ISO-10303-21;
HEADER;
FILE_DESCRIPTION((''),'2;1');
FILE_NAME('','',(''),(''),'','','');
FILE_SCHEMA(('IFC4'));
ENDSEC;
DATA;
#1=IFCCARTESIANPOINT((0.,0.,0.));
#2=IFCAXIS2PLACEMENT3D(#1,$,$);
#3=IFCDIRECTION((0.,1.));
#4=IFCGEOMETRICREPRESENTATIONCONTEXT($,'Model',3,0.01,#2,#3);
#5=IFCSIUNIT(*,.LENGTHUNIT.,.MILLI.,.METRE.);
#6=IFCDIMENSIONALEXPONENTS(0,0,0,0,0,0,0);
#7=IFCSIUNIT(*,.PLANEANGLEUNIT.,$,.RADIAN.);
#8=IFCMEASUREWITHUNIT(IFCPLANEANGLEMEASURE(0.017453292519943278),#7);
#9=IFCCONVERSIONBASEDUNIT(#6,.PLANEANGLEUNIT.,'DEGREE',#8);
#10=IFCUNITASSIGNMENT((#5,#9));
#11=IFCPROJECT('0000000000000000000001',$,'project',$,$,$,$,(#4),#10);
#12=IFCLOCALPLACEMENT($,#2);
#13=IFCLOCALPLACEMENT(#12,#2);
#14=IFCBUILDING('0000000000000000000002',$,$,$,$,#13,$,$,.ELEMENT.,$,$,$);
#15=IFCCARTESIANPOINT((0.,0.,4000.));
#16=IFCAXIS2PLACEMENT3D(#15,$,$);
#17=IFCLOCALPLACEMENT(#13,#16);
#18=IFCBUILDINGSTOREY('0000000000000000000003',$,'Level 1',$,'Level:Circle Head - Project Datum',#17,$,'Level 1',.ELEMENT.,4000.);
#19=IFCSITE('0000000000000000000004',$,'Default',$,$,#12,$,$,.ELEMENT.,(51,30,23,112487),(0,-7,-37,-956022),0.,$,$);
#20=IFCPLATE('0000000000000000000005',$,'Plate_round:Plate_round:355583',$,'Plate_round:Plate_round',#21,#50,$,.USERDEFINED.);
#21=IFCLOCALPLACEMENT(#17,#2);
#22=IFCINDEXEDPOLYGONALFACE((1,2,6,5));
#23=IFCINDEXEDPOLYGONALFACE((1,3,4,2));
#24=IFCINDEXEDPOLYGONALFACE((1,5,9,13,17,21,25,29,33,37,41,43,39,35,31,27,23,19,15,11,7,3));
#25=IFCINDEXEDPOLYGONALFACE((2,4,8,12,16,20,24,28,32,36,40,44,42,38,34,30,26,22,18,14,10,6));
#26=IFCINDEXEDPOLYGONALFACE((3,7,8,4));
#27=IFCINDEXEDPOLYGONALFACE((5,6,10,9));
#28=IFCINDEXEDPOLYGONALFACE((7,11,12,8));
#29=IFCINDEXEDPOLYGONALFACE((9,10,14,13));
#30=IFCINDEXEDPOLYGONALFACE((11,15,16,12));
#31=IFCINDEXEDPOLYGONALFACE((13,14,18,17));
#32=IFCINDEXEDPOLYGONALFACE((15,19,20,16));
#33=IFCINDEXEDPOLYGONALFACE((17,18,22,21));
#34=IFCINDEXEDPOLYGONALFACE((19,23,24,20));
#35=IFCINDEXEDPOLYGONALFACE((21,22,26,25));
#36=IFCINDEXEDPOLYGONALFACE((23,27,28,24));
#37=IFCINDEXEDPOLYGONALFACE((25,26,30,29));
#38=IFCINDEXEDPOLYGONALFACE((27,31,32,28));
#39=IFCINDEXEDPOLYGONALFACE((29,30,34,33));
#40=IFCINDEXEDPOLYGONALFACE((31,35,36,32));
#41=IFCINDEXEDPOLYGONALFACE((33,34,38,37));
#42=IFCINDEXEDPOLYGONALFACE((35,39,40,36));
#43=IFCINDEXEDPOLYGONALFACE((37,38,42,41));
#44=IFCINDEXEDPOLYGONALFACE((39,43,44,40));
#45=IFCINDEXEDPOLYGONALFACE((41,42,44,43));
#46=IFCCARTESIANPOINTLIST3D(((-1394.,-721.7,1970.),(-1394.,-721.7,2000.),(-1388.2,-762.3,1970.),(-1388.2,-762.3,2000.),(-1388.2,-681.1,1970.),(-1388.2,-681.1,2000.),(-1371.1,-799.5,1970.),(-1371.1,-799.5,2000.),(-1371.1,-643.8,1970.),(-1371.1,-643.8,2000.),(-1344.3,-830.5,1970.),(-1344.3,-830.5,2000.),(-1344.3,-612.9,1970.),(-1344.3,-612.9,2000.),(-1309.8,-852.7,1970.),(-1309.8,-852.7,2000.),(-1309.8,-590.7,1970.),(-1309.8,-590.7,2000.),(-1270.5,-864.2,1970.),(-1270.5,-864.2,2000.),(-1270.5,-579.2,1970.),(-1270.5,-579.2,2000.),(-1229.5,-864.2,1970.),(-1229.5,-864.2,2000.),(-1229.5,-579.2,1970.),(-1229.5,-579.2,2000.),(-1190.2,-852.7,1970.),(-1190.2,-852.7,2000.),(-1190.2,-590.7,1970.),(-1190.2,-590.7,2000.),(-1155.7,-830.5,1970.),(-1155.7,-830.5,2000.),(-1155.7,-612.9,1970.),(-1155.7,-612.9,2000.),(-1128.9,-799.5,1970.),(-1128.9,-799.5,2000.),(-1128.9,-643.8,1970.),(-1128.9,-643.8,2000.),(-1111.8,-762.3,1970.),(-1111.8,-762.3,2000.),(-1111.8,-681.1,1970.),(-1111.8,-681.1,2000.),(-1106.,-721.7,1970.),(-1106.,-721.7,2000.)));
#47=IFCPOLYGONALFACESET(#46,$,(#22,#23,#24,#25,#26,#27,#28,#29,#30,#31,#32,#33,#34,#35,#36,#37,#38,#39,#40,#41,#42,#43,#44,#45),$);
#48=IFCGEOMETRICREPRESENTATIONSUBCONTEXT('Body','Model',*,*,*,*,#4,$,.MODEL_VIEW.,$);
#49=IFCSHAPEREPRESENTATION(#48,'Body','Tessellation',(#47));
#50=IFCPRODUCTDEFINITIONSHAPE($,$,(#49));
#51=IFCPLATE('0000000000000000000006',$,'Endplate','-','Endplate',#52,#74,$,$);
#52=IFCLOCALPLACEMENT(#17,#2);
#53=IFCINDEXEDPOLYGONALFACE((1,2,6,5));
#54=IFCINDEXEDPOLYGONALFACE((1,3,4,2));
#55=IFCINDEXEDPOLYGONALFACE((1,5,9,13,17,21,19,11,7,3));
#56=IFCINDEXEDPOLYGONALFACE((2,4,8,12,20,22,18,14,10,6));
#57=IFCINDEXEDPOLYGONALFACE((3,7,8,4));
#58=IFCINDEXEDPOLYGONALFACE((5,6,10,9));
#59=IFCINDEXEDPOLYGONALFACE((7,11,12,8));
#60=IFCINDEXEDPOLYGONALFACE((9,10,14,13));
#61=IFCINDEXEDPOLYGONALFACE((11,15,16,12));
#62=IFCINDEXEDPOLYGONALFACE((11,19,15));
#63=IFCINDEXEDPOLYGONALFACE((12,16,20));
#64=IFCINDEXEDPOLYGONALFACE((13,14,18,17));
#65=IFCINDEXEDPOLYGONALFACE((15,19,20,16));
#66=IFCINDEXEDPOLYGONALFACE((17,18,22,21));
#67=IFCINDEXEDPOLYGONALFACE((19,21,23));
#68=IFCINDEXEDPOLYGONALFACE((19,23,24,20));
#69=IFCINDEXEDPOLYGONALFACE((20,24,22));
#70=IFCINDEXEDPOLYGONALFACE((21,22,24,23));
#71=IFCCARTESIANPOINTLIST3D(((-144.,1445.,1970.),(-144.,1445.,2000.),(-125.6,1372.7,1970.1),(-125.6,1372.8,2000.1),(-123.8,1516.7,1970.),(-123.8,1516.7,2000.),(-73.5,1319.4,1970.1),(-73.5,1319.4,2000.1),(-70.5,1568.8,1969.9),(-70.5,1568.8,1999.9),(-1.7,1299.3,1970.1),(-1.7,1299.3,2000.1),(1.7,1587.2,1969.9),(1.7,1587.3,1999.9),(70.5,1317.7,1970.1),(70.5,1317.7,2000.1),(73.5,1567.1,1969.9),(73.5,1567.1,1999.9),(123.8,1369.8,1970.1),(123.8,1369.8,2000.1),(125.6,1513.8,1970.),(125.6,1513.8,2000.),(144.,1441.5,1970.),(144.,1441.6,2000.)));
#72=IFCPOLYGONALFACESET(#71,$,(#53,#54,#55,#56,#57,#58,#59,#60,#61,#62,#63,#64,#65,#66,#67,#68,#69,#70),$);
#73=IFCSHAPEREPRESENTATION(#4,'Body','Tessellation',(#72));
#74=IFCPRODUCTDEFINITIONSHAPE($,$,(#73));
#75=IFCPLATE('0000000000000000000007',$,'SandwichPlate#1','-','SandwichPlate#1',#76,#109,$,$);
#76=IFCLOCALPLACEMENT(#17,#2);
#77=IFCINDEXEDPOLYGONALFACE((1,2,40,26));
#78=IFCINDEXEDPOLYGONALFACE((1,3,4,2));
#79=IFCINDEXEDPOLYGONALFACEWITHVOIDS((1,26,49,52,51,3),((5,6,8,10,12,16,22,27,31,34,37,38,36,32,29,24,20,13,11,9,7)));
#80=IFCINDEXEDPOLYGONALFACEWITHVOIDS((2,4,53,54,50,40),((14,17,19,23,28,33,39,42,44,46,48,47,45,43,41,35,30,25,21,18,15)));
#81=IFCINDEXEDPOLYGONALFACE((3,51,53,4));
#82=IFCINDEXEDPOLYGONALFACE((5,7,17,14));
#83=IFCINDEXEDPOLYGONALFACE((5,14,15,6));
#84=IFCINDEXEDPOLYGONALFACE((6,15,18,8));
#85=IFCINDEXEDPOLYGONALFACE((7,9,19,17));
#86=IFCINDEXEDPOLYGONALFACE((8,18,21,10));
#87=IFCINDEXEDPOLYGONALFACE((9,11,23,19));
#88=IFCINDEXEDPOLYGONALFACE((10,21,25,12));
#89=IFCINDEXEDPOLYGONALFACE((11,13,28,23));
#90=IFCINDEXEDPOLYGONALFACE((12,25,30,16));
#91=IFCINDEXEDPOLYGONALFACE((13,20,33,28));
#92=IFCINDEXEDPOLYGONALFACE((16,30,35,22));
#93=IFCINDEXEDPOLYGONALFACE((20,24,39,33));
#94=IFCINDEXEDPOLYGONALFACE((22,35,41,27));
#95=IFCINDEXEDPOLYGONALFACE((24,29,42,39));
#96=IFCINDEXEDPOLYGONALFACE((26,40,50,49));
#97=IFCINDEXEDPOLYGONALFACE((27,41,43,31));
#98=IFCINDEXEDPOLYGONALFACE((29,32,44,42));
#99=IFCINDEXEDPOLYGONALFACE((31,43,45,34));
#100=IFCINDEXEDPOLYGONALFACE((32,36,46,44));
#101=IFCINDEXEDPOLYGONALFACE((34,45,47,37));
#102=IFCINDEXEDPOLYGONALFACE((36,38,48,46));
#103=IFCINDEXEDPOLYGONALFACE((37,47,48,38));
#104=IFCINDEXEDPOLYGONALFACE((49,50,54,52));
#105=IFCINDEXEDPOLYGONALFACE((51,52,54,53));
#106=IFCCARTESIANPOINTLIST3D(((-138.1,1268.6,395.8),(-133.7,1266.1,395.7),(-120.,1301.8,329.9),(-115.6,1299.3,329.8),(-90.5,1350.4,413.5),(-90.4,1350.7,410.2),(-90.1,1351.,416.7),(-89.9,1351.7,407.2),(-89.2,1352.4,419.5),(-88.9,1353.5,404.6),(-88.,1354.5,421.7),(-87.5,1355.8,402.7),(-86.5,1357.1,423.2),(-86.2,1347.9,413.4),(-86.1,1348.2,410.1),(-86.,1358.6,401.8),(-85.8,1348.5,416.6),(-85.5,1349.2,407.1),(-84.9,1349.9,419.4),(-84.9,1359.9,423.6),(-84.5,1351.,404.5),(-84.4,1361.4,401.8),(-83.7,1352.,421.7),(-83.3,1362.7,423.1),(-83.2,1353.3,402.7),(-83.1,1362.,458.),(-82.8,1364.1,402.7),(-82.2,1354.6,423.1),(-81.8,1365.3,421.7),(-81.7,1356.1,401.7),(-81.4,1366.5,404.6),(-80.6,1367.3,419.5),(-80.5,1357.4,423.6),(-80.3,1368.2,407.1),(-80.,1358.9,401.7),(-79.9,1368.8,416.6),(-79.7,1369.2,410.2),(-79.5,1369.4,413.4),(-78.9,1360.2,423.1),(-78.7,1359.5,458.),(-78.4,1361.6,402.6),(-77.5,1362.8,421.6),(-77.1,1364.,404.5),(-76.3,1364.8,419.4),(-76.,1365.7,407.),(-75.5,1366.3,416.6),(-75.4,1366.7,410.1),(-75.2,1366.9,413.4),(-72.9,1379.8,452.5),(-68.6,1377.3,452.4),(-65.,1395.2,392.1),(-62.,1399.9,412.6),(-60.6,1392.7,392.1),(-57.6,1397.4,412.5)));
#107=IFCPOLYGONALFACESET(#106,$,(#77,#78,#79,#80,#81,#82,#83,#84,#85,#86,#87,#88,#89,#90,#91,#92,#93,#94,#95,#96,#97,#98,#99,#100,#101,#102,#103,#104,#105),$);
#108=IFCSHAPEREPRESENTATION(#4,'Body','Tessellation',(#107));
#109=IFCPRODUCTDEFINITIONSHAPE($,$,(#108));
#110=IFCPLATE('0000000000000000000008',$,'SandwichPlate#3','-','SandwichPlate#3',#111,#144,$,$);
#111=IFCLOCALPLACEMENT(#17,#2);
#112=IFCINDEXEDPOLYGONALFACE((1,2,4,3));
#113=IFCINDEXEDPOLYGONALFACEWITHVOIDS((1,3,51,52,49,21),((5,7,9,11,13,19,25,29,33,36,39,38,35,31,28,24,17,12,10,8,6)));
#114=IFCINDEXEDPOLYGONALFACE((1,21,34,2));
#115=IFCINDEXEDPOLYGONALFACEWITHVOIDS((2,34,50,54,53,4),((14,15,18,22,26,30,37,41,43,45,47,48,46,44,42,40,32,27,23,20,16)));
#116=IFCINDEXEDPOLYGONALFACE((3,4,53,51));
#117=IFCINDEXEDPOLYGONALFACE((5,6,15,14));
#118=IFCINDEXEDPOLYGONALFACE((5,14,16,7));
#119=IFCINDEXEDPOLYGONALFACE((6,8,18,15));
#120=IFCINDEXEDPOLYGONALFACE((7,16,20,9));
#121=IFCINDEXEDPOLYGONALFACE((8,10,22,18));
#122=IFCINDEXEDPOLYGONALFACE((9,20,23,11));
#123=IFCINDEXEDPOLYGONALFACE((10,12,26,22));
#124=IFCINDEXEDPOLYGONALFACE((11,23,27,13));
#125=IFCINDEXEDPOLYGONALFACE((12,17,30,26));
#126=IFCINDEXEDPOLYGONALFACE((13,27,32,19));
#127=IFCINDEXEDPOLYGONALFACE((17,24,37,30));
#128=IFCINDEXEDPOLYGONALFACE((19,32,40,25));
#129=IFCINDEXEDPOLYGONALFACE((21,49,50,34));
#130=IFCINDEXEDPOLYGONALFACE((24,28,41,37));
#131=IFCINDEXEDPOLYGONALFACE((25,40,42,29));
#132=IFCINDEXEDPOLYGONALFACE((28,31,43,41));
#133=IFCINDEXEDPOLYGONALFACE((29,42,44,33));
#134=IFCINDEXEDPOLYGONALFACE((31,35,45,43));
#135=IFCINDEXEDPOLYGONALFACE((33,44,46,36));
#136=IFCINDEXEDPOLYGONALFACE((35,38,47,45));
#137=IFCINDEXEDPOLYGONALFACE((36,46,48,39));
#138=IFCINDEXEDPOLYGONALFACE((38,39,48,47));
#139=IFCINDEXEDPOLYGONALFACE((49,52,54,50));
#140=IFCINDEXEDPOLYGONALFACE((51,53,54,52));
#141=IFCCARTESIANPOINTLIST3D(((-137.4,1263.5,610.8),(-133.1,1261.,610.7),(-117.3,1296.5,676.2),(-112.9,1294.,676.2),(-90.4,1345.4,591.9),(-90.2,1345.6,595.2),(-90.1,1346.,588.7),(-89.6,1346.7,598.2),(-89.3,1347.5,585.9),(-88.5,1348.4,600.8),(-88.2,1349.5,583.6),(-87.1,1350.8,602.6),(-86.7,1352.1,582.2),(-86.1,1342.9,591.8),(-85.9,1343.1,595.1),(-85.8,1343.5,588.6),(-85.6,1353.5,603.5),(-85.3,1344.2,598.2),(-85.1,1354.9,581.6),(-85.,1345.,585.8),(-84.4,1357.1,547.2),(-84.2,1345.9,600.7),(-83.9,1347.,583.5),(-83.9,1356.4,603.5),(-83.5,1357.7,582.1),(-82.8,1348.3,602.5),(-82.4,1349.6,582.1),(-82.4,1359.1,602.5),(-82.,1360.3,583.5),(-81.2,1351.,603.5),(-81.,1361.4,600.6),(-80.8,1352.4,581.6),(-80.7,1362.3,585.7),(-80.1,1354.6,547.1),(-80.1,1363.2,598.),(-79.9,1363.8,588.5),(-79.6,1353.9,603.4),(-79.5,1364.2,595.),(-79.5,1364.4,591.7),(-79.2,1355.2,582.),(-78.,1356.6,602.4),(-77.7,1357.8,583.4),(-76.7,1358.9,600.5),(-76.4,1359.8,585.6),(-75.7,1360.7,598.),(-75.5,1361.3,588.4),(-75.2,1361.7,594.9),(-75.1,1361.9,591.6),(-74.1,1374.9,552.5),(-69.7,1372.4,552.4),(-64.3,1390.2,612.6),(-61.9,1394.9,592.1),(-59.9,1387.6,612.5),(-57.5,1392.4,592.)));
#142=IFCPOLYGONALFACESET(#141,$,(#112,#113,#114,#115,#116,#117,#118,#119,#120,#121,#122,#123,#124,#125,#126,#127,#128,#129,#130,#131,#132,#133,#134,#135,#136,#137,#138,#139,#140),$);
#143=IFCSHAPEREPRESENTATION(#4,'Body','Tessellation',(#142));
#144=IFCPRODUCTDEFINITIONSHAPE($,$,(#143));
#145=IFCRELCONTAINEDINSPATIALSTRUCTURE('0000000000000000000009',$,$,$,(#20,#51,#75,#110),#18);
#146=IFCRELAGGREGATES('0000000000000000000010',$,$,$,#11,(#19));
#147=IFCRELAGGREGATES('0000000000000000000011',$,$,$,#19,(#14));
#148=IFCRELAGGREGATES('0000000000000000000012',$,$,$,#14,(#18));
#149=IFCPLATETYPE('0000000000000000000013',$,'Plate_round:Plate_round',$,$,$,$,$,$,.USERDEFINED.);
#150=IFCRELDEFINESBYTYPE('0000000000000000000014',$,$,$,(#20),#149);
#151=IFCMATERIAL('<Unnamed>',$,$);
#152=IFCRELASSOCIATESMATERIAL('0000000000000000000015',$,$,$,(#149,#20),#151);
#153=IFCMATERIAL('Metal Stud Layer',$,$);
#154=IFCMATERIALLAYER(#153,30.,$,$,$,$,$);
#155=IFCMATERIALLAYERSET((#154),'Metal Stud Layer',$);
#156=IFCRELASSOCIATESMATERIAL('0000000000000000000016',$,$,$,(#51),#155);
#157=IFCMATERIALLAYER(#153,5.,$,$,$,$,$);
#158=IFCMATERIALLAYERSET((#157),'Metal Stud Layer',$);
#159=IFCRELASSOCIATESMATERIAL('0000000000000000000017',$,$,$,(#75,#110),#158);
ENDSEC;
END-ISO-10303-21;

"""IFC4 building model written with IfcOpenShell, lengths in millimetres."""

from ifc_helpers import new_model, entity, si_unit, converted_unit, point, direction, frame, frame_2d, origin, origin_with_axes, origin_2d_with_axis, place, context, subcontext, project, spatial, polyline, arc, indexed_curve, circle_curve, line_curve, trimmed, segment, composite_curve, circle, outline, extrude, source, transform, mapped, material, layer, layer_set, type_object, type_shapes, element, save


model = new_model("IFC4")

# Units and contexts
model_context = context("Model", 3, precision=0.01, world=origin(), true_north=direction((0.0, 1.0)))
body_context = subcontext(model_context, "Body", "Model", "MODEL_VIEW")
ifc_project = project(units=[si_unit("LENGTHUNIT", "METRE", prefix="MILLI"), converted_unit("PLANEANGLEUNIT", "DEGREE", entity("IfcPlaneAngleMeasure", 0.017453292519943278), si_unit("PLANEANGLEUNIT", "RADIAN"), dimensions=[0, 0, 0, 0, 0, 0, 0])], contexts=[model_context])

# Site, building, storey
site_placement = place(None, origin())
site = spatial("IfcSite", under=ifc_project, at=site_placement, Name="Default", CompositionType="ELEMENT", RefLatitude=(51, 30, 23, 112487), RefLongitude=(0, -7, -37, -956022), RefElevation=0.0)
building_placement = place(site_placement, origin())
building = spatial("IfcBuilding", under=site, at=building_placement, CompositionType="ELEMENT")
storey_placement = place(building_placement, frame((0.0, 0.0, 4000.0)))
storey = spatial("IfcBuildingStorey", under=building, at=storey_placement, Name="Level 1", ObjectType="Level:Circle Head - Project Datum", LongName="Level 1", CompositionType="ELEMENT", Elevation=4000.0)

# Plate
ifc_material_1 = material(Name="<Unnamed>")
plate_type = type_object("IfcPlateType", Name="Plate_round:Plate_round", PredefinedType="USERDEFINED", material=ifc_material_1)
shared_shape = source(origin(), body_context, "Body", "SweptSolid", [
    extrude(outline(indexed_curve([(-144.0, 0.0), (0.0, -144.0), (144.0, 0.0), (0.0, 144.0)], segments=[arc(1, 2, 3), arc(3, 4, 1)], self_intersect=False)), origin(), (0.0, 0.0, 1.0), 30.0),
])
type_shapes(plate_type, [shared_shape])
plate_1_placement = place(storey_placement, frame((-1250.0, -721.7, 1970.0)))
element("IfcPlate", 1, at=plate_1_placement, inside=storey, type_object=plate_type, material=ifc_material_1, Name="Plate_round:Plate_round:355583", ObjectType="Plate_round:Plate_round", PredefinedType="USERDEFINED", context=body_context, shape_type="MappedRepresentation", body=[
    mapped(shared_shape, transform((0.0, 0.0, 0.0), scale=1.0)),
])

# Plates, openings
ifc_material_2 = material(Name="Metal Stud Layer")
ifc_layer_1 = layer(ifc_material_2, 30.0)
ifc_layer_set_1 = layer_set([ifc_layer_1], Name="Metal Stud Layer")
plate_2_placement = place(storey_placement, frame((-144.0, 1445.0, 1970.0), z_axis=(0.0, 0.000811, 1.0), x_axis=(-0.011883, -0.999929, 0.000811)))
plate_2 = element("IfcPlate", 2, at=plate_2_placement, inside=storey, material=ifc_layer_set_1, Name="Endplate", Description="-", ObjectType="Endplate", context=model_context, shape_type="SweptSolid", body=[
    extrude(outline(polyline([(144.0, 0.0), (144.0, 288.0), (-144.0, 288.0), (-144.0, 0.0), (144.0, 0.0)])), origin_with_axes(), (0.0, 0.0, 1.0), 30.0),
])
opening_1_placement = place(plate_2_placement, frame((0.0, 0.0, 0.0), z_axis=(0.0, 0.0, 1.0), x_axis=(1.0, 0.0, 0.0)))
element("IfcOpeningElement", 3, at=opening_1_placement, cuts=plate_2, ObjectType="Opening", context=model_context, shape_type="SweptSolid", body=[
    extrude(outline(composite_curve([segment(trimmed(line_curve((144.0, 0.0), (0.0, 1.0), 144.0), [point((144.0, 0.0))], [point((144.0, 144.0))], True, "CARTESIAN"), True, "CONTINUOUS"), segment(trimmed(circle_curve(frame_2d((0.0, 144.0), x_axis=(-1.0, 0.0)), 144.0), [point((144.0, 144.0))], [point((0.0, 0.0))], False, "CARTESIAN"), True, "CONTINUOUS"), segment(trimmed(line_curve((0.0, 0.0), (1.0, 0.0), 144.0), [point((0.0, 0.0))], [point((144.0, 0.0))], True, "CARTESIAN"), True, "CONTINUOUS")], self_intersect="UNKNOWN")), origin(), (0.0, 0.0, 1.0), 30.0),
])
opening_2_placement = place(plate_2_placement, frame((0.0, 0.0, 0.0), z_axis=(0.0, 0.0, 1.0), x_axis=(1.0, 0.0, 0.0)))
element("IfcOpeningElement", 4, at=opening_2_placement, cuts=plate_2, ObjectType="Opening", context=model_context, shape_type="SweptSolid", body=[
    extrude(outline(composite_curve([segment(trimmed(line_curve((144.0, 288.0), (-1.0, 0.0), 144.0), [point((144.0, 288.0))], [point((0.0, 288.0))], True, "CARTESIAN"), True, "CONTINUOUS"), segment(trimmed(circle_curve(frame_2d((0.0, 144.0), x_axis=(-1.0, 0.0)), 144.0), [point((0.0, 288.0))], [point((144.0, 144.0))], False, "CARTESIAN"), True, "CONTINUOUS"), segment(trimmed(line_curve((144.0, 144.0), (0.0, 1.0), 144.0), [point((144.0, 144.0))], [point((144.0, 288.0))], True, "CARTESIAN"), True, "CONTINUOUS")], self_intersect="UNKNOWN")), origin(), (0.0, 0.0, 1.0), 30.0),
])
opening_3_placement = place(plate_2_placement, frame((0.0, 0.0, 0.0), z_axis=(0.0, 0.0, 1.0), x_axis=(1.0, 0.0, 0.0)))
element("IfcOpeningElement", 5, at=opening_3_placement, cuts=plate_2, ObjectType="Opening", context=model_context, shape_type="SweptSolid", body=[
    extrude(outline(composite_curve([segment(trimmed(line_curve((-144.0, 288.0), (0.0, -1.0), 144.0), [point((-144.0, 288.0))], [point((-144.0, 144.0))], True, "CARTESIAN"), True, "CONTINUOUS"), segment(trimmed(circle_curve(frame_2d((0.0, 144.0), x_axis=(-1.0, 0.0)), 144.0), [point((-144.0, 144.0))], [point((0.0, 288.0))], False, "CARTESIAN"), True, "CONTINUOUS"), segment(trimmed(line_curve((0.0, 288.0), (-1.0, 0.0), 144.0), [point((0.0, 288.0))], [point((-144.0, 288.0))], True, "CARTESIAN"), True, "CONTINUOUS")], self_intersect="UNKNOWN")), origin(), (0.0, 0.0, 1.0), 30.0),
])
opening_4_placement = place(plate_2_placement, frame((0.0, 0.0, 0.0), z_axis=(0.0, 0.0, 1.0), x_axis=(1.0, 0.0, 0.0)))
element("IfcOpeningElement", 6, at=opening_4_placement, cuts=plate_2, ObjectType="Opening", context=model_context, shape_type="SweptSolid", body=[
    extrude(outline(composite_curve([segment(trimmed(line_curve((-144.0, 0.0), (1.0, 0.0), 144.0), [point((-144.0, 0.0))], [point((0.0, 0.0))], True, "CARTESIAN"), True, "CONTINUOUS"), segment(trimmed(circle_curve(frame_2d((0.0, 144.0), x_axis=(-1.0, 0.0)), 144.0), [point((0.0, 0.0))], [point((-144.0, 144.0))], False, "CARTESIAN"), True, "CONTINUOUS"), segment(trimmed(line_curve((-144.0, 144.0), (0.0, -1.0), 144.0), [point((-144.0, 144.0))], [point((-144.0, 0.0))], True, "CARTESIAN"), True, "CONTINUOUS")], self_intersect="UNKNOWN")), origin(), (0.0, 0.0, 1.0), 30.0),
])
ifc_layer_2 = layer(ifc_material_2, 5.0)
ifc_layer_set_2 = layer_set([ifc_layer_2], Name="Metal Stud Layer")
plate_3_placement = place(storey_placement, frame((-58.4, 1406.5, 399.6), z_axis=(0.865935, -0.499948, -0.014432), x_axis=(-0.238139, -0.437501, 0.867112)))
plate_3 = element("IfcPlate", 7, at=plate_3_placement, inside=storey, material=ifc_layer_set_2, Name="SandwichPlate#1", Description="-", ObjectType="SandwichPlate#1", context=model_context, shape_type="SweptSolid", body=[
    extrude(outline(polyline([(0.0, 0.0), (76.0, 0.0), (76.0, 140.0), (0.0, 140.0), (0.0, 0.0)])), origin_with_axes(), (0.0, 0.0, 1.0), 5.0),
])
opening_5_placement = place(plate_3_placement, frame((0.0, 0.0, 0.0), z_axis=(0.0, 0.0, 1.0), x_axis=(1.0, 0.0, 0.0)))
element("IfcOpeningElement", 8, at=opening_5_placement, cuts=plate_3, ObjectType="Opening", context=model_context, shape_type="SweptSolid", body=[
    extrude(outline(polyline([(0.0, 0.0), (15.0, 0.0), (0.0, 15.0), (0.0, 0.0)])), origin(), (0.0, 0.0, 1.0), 5.0),
])
opening_6_placement = place(plate_3_placement, frame((0.0, 0.0, 0.0), z_axis=(0.0, 0.0, 1.0), x_axis=(1.0, 0.0, 0.0)))
element("IfcOpeningElement", 9, at=opening_6_placement, cuts=plate_3, ObjectType="Opening", context=model_context, shape_type="SweptSolid", body=[
    extrude(outline(polyline([(76.0, 0.0), (76.0, 15.0), (61.0, 0.0), (76.0, 0.0)])), origin(), (0.0, 0.0, 1.0), 5.0),
])
opening_7_placement = place(plate_3_placement, frame((38.0, 40.0, -0.5), z_axis=(0.0, 0.0, 1.0), x_axis=(0.0, 1.0, 0.0)))
element("IfcOpeningElement", 10, at=opening_7_placement, cuts=plate_3, ObjectType="Opening", context=model_context, shape_type="SweptSolid", body=[
    extrude(circle(Radius=11.0, at=origin_2d_with_axis()), origin(), (0.0, 0.0, 1.0), 6.0),
])
plate_4_placement = place(storey_placement, frame((-78.0, 1368.4, 539.6), z_axis=(0.865935, -0.499948, -0.014432), x_axis=(0.265222, 0.434531, 0.86072)))
plate_4 = element("IfcPlate", 11, at=plate_4_placement, inside=storey, material=ifc_layer_set_2, Name="SandwichPlate#3", Description="-", ObjectType="SandwichPlate#3", context=model_context, shape_type="SweptSolid", body=[
    extrude(outline(polyline([(0.0, 0.0), (76.0, 0.0), (76.0, 140.0), (0.0, 140.0), (0.0, 0.0)])), origin_with_axes(), (0.0, 0.0, 1.0), 5.0),
])
opening_8_placement = place(plate_4_placement, frame((0.0, 0.0, 0.0), z_axis=(0.0, 0.0, 1.0), x_axis=(1.0, 0.0, 0.0)))
element("IfcOpeningElement", 12, at=opening_8_placement, cuts=plate_4, ObjectType="Opening", context=model_context, shape_type="SweptSolid", body=[
    extrude(outline(polyline([(0.0, 0.0), (15.0, 0.0), (0.0, 15.0), (0.0, 0.0)])), origin(), (0.0, 0.0, 1.0), 5.0),
])
opening_9_placement = place(plate_4_placement, frame((0.0, 0.0, 0.0), z_axis=(0.0, 0.0, 1.0), x_axis=(1.0, 0.0, 0.0)))
element("IfcOpeningElement", 13, at=opening_9_placement, cuts=plate_4, ObjectType="Opening", context=model_context, shape_type="SweptSolid", body=[
    extrude(outline(polyline([(76.0, 0.0), (76.0, 15.0), (61.0, 0.0), (76.0, 0.0)])), origin(), (0.0, 0.0, 1.0), 5.0),
])
opening_10_placement = place(plate_4_placement, frame((38.0, 40.0, -0.5), z_axis=(0.0, 0.0, 1.0), x_axis=(0.0, 1.0, 0.0)))
element("IfcOpeningElement", 14, at=opening_10_placement, cuts=plate_4, ObjectType="Opening", context=model_context, shape_type="SweptSolid", body=[
    extrude(circle(Radius=11.0, at=origin_2d_with_axis()), origin(), (0.0, 0.0, 1.0), 6.0),
])

save(model, "model.ifc")
